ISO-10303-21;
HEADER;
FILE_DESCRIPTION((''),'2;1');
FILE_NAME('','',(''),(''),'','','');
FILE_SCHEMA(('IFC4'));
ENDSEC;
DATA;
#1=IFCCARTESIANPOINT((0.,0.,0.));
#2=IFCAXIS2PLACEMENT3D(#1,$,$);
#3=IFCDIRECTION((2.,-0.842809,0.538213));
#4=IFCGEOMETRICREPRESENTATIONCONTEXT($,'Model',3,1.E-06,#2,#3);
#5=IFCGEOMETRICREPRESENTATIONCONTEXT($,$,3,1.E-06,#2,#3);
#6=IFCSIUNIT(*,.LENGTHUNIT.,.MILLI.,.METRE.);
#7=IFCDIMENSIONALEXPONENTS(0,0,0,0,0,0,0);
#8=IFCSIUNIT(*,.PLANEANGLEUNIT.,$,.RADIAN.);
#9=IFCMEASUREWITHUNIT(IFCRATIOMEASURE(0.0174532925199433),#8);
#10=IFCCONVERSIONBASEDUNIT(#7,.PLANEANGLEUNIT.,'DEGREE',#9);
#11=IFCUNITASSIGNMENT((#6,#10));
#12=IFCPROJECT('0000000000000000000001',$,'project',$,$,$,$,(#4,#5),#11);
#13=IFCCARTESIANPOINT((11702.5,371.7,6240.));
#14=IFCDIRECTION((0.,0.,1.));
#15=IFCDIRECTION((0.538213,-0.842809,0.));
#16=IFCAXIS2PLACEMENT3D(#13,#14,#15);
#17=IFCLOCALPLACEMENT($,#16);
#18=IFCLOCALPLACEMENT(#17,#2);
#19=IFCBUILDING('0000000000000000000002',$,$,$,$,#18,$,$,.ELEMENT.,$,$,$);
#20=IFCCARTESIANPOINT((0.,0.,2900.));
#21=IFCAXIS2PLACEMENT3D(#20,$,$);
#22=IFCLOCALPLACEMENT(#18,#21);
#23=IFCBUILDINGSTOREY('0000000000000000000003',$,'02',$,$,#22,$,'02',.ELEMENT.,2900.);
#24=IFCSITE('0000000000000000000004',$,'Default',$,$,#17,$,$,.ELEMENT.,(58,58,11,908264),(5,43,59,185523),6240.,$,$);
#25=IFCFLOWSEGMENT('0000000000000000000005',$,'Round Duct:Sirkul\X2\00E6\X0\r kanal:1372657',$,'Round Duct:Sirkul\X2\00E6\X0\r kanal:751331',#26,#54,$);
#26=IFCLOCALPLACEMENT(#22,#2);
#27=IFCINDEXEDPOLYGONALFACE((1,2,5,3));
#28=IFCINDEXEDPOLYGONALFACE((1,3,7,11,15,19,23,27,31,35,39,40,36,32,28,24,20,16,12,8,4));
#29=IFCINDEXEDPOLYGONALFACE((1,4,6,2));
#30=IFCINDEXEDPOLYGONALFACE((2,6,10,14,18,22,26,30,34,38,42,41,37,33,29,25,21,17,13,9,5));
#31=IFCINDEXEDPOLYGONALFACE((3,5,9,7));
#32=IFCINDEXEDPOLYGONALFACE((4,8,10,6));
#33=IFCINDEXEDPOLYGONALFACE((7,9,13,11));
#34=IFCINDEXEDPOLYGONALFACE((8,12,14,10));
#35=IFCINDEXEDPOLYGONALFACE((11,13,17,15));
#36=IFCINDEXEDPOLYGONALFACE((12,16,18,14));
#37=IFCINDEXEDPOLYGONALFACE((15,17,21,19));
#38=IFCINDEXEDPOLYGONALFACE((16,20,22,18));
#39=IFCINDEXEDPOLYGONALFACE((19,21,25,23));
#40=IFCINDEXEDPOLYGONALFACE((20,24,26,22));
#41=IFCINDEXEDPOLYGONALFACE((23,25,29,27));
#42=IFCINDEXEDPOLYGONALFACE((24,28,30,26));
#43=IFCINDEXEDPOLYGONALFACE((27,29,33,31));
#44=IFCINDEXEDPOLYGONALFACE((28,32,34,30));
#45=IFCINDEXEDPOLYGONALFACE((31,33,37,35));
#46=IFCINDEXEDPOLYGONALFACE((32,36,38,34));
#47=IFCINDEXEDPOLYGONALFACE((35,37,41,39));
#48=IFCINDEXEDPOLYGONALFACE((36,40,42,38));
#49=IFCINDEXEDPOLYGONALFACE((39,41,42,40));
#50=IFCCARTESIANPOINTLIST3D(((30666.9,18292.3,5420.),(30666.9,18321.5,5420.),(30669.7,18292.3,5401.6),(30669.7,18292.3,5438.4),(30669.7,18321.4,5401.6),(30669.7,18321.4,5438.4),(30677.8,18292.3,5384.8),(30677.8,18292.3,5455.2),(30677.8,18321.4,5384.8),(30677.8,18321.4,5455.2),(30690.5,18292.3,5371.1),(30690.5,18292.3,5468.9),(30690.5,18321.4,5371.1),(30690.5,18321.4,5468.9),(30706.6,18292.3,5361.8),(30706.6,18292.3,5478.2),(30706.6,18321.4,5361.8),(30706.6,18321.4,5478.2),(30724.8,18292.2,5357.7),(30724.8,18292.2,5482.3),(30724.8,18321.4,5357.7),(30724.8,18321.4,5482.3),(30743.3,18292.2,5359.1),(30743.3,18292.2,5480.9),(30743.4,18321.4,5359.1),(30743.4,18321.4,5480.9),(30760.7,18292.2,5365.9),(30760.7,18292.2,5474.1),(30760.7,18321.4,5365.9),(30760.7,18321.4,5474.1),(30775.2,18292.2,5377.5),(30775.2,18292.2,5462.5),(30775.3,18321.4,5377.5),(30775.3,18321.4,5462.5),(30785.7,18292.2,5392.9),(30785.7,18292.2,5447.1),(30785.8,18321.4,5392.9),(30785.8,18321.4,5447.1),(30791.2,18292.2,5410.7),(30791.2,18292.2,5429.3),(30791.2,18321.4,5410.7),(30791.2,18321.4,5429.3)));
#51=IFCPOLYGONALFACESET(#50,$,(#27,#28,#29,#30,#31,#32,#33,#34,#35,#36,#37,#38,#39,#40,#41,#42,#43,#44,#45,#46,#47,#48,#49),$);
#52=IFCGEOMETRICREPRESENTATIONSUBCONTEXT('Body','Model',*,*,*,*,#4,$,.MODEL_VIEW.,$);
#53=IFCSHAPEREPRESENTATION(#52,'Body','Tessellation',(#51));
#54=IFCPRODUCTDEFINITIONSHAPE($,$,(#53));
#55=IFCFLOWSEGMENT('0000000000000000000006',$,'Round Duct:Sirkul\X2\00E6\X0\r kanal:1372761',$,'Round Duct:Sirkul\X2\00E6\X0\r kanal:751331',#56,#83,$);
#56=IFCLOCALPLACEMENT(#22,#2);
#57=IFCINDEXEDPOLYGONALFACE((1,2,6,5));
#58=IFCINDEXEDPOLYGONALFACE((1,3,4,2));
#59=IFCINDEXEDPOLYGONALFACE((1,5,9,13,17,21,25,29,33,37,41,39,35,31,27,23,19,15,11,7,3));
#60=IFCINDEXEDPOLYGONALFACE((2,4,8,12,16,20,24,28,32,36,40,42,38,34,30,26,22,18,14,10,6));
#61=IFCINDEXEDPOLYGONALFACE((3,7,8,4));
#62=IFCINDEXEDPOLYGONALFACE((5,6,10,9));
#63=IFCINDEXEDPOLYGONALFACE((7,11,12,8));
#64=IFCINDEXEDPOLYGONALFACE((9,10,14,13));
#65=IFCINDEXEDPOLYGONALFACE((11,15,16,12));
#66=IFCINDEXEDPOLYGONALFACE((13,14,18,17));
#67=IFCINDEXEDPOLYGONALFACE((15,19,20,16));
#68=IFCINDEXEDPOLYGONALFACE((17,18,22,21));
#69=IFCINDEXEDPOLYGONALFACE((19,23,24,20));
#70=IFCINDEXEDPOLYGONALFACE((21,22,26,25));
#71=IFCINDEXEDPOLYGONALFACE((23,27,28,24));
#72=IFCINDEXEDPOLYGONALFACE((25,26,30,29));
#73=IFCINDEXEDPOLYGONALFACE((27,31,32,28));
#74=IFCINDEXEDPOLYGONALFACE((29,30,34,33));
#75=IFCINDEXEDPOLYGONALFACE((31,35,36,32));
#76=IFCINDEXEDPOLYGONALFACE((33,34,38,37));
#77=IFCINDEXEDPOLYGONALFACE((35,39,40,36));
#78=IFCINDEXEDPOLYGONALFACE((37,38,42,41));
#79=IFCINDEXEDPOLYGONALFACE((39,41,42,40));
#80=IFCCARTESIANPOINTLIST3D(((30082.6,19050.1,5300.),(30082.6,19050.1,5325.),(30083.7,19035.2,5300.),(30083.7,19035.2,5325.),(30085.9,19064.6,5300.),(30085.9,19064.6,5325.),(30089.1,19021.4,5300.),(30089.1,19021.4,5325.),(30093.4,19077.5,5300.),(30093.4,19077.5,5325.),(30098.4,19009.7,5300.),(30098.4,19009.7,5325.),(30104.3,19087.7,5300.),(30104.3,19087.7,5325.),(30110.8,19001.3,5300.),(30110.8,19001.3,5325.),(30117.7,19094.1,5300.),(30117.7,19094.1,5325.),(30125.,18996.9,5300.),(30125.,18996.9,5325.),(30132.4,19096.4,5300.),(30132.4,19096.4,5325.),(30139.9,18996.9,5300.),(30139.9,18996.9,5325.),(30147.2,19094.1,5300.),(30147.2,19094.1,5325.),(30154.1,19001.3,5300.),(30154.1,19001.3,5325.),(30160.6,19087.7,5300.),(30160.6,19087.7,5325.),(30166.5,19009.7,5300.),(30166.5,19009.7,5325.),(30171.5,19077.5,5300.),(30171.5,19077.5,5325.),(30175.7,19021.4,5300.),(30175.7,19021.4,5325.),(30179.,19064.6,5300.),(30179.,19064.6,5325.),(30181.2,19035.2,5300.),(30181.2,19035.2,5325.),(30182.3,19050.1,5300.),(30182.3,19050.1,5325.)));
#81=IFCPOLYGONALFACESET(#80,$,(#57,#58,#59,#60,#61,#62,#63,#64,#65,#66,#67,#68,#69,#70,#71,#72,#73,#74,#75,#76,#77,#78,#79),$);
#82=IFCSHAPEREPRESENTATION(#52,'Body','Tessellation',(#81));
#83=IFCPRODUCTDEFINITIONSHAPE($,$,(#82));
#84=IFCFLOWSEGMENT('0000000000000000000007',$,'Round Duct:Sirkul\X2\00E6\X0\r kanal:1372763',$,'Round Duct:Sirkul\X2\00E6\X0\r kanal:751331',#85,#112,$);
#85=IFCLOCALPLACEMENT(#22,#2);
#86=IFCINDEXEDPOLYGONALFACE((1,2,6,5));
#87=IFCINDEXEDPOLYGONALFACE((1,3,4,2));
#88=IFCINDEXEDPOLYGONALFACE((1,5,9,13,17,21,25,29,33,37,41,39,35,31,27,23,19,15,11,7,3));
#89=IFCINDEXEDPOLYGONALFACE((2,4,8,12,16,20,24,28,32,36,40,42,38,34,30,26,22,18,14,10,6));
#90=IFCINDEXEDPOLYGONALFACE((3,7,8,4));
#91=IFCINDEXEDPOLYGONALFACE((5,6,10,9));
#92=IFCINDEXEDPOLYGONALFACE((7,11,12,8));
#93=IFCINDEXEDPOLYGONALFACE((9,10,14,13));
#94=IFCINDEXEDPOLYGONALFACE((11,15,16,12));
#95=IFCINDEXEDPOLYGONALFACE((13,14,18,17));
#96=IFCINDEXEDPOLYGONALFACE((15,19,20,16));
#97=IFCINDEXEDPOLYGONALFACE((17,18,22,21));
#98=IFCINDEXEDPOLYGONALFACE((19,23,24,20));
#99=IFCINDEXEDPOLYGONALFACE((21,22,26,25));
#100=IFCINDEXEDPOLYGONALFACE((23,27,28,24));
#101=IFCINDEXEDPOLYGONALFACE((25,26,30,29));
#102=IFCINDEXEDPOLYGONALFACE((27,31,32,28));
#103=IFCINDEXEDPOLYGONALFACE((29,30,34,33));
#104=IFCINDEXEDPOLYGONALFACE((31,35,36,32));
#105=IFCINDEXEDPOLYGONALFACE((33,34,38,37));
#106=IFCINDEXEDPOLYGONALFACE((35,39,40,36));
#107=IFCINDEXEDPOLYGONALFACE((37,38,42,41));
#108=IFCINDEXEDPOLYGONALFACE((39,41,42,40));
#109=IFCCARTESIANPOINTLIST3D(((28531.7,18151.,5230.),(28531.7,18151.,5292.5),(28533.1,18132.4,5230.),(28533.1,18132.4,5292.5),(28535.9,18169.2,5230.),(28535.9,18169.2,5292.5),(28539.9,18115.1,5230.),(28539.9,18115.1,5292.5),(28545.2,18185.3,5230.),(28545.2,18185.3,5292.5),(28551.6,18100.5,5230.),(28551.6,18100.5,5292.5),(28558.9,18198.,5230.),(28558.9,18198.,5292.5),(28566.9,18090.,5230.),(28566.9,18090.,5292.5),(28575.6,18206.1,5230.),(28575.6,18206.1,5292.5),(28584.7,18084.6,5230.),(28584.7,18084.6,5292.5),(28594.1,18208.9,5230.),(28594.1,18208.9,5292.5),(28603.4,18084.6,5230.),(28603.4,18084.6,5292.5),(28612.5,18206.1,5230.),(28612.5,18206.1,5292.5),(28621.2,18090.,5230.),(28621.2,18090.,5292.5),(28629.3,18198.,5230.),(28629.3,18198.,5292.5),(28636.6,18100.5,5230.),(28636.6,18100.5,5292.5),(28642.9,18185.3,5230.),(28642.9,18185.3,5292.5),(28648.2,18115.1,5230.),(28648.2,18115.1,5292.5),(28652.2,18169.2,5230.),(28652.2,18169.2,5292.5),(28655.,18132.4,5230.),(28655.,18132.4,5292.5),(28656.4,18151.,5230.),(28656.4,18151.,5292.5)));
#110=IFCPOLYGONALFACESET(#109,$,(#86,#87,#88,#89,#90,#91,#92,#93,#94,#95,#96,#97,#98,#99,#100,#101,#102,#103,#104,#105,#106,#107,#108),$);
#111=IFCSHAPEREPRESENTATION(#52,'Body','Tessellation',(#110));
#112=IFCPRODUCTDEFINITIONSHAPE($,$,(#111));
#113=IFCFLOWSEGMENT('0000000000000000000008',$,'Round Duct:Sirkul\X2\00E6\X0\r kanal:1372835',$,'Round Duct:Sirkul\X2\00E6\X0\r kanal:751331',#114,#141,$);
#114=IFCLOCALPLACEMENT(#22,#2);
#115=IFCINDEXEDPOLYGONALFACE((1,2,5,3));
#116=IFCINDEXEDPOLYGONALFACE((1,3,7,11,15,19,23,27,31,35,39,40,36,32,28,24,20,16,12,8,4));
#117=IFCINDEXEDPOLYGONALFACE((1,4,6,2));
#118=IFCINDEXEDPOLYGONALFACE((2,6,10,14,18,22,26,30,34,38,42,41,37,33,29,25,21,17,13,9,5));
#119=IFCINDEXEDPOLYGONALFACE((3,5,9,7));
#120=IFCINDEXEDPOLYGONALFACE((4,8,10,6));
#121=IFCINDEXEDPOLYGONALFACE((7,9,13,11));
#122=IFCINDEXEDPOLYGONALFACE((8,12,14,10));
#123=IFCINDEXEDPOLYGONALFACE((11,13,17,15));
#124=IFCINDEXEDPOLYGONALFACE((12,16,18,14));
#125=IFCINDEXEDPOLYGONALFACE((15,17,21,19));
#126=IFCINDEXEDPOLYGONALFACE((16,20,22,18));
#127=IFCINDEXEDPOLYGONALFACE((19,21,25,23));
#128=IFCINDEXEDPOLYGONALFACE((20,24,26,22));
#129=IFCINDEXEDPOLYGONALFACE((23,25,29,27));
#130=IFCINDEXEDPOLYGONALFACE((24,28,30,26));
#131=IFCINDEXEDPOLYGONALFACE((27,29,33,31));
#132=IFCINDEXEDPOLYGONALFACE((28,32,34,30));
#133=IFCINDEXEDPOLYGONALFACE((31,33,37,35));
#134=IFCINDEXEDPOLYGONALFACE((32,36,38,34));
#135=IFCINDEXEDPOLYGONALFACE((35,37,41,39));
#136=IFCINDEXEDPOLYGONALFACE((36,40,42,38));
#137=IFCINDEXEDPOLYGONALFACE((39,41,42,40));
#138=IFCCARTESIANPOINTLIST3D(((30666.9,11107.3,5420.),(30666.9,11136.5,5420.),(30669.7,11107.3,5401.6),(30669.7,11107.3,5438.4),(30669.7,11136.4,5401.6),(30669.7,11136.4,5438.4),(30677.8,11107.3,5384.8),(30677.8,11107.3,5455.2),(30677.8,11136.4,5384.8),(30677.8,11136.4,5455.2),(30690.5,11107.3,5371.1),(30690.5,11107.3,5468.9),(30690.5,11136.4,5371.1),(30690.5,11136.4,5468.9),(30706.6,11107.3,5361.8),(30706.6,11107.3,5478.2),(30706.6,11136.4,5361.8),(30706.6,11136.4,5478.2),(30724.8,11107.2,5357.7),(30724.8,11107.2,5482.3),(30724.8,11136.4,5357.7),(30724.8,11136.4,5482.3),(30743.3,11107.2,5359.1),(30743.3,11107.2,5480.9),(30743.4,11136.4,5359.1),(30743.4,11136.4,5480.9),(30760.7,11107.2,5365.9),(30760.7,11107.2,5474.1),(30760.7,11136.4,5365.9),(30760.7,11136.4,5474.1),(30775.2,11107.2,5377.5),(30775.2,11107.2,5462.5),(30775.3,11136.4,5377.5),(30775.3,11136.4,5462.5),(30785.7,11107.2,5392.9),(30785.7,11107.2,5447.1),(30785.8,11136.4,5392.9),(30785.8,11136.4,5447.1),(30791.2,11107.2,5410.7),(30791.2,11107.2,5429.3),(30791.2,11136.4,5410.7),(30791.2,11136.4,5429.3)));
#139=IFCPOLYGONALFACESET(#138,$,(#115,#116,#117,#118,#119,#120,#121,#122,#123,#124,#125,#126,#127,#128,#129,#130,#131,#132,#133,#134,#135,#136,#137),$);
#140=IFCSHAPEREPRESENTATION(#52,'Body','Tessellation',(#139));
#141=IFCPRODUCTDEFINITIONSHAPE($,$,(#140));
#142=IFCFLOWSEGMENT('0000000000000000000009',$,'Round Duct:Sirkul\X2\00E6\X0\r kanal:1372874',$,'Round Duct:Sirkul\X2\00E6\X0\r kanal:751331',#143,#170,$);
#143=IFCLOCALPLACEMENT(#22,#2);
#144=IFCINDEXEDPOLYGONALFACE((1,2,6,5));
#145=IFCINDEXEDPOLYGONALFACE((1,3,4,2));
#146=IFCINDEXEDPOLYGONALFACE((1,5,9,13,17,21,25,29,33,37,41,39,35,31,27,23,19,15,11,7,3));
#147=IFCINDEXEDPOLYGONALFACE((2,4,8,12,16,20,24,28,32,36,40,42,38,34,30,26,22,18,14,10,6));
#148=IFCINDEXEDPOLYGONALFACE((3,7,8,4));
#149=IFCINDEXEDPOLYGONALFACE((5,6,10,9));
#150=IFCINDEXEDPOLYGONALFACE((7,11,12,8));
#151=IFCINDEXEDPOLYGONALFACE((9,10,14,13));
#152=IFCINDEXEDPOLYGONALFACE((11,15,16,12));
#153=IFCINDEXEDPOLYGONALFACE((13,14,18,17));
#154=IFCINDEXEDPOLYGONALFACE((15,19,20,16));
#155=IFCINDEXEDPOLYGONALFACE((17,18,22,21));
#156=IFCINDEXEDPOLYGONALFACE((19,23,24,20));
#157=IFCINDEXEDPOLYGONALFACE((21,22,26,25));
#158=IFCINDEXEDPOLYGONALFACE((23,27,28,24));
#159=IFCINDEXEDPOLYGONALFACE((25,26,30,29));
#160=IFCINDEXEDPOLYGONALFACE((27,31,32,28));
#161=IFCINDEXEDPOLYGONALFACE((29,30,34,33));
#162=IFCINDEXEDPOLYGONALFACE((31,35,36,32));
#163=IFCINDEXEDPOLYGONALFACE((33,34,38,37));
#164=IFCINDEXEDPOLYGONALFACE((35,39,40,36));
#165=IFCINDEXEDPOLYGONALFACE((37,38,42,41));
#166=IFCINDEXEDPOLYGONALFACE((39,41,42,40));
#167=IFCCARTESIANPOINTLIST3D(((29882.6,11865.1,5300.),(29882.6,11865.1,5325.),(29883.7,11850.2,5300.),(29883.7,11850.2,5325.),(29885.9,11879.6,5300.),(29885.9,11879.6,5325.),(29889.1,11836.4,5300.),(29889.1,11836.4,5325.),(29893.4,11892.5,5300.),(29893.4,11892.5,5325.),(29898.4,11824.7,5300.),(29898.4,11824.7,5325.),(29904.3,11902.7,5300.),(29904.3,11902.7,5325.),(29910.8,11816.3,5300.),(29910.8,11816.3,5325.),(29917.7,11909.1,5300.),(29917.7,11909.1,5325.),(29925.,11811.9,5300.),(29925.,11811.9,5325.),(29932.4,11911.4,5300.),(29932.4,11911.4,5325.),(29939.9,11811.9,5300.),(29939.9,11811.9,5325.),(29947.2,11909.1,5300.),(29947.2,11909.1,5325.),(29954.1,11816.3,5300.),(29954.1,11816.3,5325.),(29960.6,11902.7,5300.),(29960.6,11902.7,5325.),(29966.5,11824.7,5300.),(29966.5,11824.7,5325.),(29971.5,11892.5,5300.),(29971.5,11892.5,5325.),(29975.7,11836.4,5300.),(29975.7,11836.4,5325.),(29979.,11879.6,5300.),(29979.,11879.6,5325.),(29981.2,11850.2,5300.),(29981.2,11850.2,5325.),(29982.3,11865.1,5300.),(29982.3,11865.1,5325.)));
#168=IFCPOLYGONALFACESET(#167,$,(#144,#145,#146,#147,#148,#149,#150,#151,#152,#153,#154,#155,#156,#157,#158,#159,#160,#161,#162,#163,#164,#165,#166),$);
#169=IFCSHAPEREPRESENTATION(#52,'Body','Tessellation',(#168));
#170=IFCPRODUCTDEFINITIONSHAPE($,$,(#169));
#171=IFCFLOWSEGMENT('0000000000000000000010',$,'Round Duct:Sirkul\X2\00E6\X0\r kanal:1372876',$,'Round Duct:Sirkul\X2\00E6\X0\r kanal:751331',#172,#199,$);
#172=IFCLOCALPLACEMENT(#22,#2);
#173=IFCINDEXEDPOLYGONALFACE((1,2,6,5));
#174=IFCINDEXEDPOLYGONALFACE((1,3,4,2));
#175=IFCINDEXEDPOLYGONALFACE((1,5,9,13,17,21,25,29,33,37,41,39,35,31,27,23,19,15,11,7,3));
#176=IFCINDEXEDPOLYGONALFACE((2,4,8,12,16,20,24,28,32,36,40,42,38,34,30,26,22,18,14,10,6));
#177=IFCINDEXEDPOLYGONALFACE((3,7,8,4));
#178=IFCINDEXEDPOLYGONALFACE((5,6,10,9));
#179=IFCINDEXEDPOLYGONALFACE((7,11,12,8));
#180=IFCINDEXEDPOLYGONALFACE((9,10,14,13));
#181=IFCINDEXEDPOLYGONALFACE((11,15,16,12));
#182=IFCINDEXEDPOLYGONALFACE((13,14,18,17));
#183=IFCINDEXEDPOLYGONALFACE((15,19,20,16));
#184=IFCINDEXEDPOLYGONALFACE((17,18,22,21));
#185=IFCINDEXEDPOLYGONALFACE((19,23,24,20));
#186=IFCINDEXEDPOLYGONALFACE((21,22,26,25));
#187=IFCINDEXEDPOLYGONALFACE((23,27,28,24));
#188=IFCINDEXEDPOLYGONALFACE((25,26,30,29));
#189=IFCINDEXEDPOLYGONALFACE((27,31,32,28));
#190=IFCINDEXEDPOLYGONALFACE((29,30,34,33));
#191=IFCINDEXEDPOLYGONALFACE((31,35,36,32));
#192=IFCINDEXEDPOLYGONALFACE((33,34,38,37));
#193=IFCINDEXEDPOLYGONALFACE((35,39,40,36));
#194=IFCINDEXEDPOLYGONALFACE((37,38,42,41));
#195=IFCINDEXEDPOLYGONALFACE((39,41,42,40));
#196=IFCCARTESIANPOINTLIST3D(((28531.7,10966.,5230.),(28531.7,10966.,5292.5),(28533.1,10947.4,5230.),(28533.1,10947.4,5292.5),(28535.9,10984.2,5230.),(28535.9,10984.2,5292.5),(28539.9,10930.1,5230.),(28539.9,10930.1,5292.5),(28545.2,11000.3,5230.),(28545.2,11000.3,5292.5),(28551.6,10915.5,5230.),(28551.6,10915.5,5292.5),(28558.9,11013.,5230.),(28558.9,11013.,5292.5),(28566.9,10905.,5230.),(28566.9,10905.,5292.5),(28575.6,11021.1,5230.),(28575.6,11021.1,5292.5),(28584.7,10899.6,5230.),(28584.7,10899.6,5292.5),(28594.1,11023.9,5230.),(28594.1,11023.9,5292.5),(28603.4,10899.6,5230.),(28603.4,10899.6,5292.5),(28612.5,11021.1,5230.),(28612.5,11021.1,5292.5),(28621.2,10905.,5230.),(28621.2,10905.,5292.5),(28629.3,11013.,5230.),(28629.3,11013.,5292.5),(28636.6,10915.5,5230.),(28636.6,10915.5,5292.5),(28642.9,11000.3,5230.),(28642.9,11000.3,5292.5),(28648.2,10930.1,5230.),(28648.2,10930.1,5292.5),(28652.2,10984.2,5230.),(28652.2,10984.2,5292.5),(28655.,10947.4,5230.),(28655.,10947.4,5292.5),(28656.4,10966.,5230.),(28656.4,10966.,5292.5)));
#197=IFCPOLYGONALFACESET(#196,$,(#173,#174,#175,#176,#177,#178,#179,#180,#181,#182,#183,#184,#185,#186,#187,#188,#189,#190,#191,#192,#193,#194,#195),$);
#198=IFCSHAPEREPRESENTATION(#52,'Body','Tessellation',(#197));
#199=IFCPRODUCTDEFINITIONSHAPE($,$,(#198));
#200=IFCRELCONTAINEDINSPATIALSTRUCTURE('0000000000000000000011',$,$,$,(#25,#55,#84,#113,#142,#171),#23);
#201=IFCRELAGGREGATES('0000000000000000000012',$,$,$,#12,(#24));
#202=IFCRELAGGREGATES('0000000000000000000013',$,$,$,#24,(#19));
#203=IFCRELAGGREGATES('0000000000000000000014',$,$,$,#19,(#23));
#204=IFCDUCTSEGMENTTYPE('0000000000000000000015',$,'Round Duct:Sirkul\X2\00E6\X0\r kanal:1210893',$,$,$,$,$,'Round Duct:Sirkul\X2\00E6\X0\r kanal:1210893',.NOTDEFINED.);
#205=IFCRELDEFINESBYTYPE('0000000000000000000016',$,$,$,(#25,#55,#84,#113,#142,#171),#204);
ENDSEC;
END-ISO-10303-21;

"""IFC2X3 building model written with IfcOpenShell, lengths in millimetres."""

from ifc_helpers import new_model, entity, si_unit, converted_unit, direction, frame, frame_2d, origin, origin_2d_with_axis, place, context, subcontext, project, spatial, circle, extrude, type_object, element, save


model = new_model("IFC2X3")

# Units and contexts
model_context = context("Model", 3, precision=1e-06, world=origin(), true_north=direction((2.0, -0.842809, 0.538213)))
context_of_model = context(None, 3, precision=1e-06, world=origin(), true_north=direction((2.0, -0.842809, 0.538213)))
body_context = subcontext(model_context, "Body", "Model", "MODEL_VIEW")
ifc_project = project(units=[si_unit("LENGTHUNIT", "METRE", prefix="MILLI"), converted_unit("PLANEANGLEUNIT", "DEGREE", entity("IfcRatioMeasure", 0.0174532925199433), si_unit("PLANEANGLEUNIT", "RADIAN"), dimensions=[0, 0, 0, 0, 0, 0, 0])], contexts=[model_context, context_of_model])

# Site, building, storey
site_placement = place(None, frame((11702.5, 371.7, 6240.0), z_axis=(0.0, 0.0, 1.0), x_axis=(0.538213, -0.842809, 0.0)))
site = spatial("IfcSite", under=ifc_project, at=site_placement, Name="Default", CompositionType="ELEMENT", RefLatitude=(58, 58, 11, 908264), RefLongitude=(5, 43, 59, 185523), RefElevation=6240.0)
building_placement = place(site_placement, origin())
building = spatial("IfcBuilding", under=site, at=building_placement, CompositionType="ELEMENT")
storey_placement = place(building_placement, frame((0.0, 0.0, 2900.0)))
storey = spatial("IfcBuildingStorey", under=building, at=storey_placement, Name="02", LongName="02", CompositionType="ELEMENT", Elevation=2900.0)

# Flow segments
duct_segment_type = type_object("IfcDuctSegmentType", Name="Round Duct:Sirkulær kanal:1210893", ElementType="Round Duct:Sirkulær kanal:1210893", PredefinedType="NOTDEFINED")
flow_segment_1_placement = place(storey_placement, origin())
element("IfcFlowSegment", 1, at=flow_segment_1_placement, inside=storey, type_object=duct_segment_type, Name="Round Duct:Sirkulær kanal:1372657", ObjectType="Round Duct:Sirkulær kanal:751331", context=body_context, shape_type="SweptSolid", body=[
    extrude(circle(Radius=62.5, at=origin_2d_with_axis()), frame((30729.4, 18292.2, 5420.0), z_axis=(0.000629, 1.0, 0.0), x_axis=(-1.0, 0.000629, 0.0)), (0.0, 0.0, 1.0), 29.2),
])
flow_segment_2_placement = place(storey_placement, origin())
element("IfcFlowSegment", 2, at=flow_segment_2_placement, inside=storey, type_object=duct_segment_type, Name="Round Duct:Sirkulær kanal:1372761", ObjectType="Round Duct:Sirkulær kanal:751331", context=body_context, shape_type="SweptSolid", body=[
    extrude(circle(Radius=50.0, at=frame_2d((0.0, 0.0), x_axis=(1.0, 0.0))), frame((30132.4, 19046.4, 5300.0), z_axis=(0.0, 0.0, 1.0), x_axis=(0.0, 1.0, 0.0)), (0.0, 0.0, 1.0), 25.0),
])
flow_segment_3_placement = place(storey_placement, origin())
element("IfcFlowSegment", 3, at=flow_segment_3_placement, inside=storey, type_object=duct_segment_type, Name="Round Duct:Sirkulær kanal:1372763", ObjectType="Round Duct:Sirkulær kanal:751331", context=body_context, shape_type="SweptSolid", body=[
    extrude(circle(Radius=62.5, at=frame_2d((0.0, 0.0), x_axis=(1.0, 0.0))), frame((28594.1, 18146.4, 5230.0), z_axis=(0.0, 0.0, 1.0), x_axis=(0.0, 1.0, 0.0)), (0.0, 0.0, 1.0), 62.5),
])
flow_segment_4_placement = place(storey_placement, origin())
element("IfcFlowSegment", 4, at=flow_segment_4_placement, inside=storey, type_object=duct_segment_type, Name="Round Duct:Sirkulær kanal:1372835", ObjectType="Round Duct:Sirkulær kanal:751331", context=body_context, shape_type="SweptSolid", body=[
    extrude(circle(Radius=62.5, at=origin_2d_with_axis()), frame((30729.4, 11107.2, 5420.0), z_axis=(0.000629, 1.0, 0.0), x_axis=(-1.0, 0.000629, 0.0)), (0.0, 0.0, 1.0), 29.2),
])
flow_segment_5_placement = place(storey_placement, origin())
element("IfcFlowSegment", 5, at=flow_segment_5_placement, inside=storey, type_object=duct_segment_type, Name="Round Duct:Sirkulær kanal:1372874", ObjectType="Round Duct:Sirkulær kanal:751331", context=body_context, shape_type="SweptSolid", body=[
    extrude(circle(Radius=50.0, at=frame_2d((0.0, 0.0), x_axis=(1.0, 0.0))), frame((29932.4, 11861.4, 5300.0), z_axis=(0.0, 0.0, 1.0), x_axis=(0.0, 1.0, 0.0)), (0.0, 0.0, 1.0), 25.0),
])
flow_segment_6_placement = place(storey_placement, origin())
element("IfcFlowSegment", 6, at=flow_segment_6_placement, inside=storey, type_object=duct_segment_type, Name="Round Duct:Sirkulær kanal:1372876", ObjectType="Round Duct:Sirkulær kanal:751331", context=body_context, shape_type="SweptSolid", body=[
    extrude(circle(Radius=62.5, at=frame_2d((0.0, 0.0), x_axis=(1.0, 0.0))), frame((28594.1, 10961.4, 5230.0), z_axis=(0.0, 0.0, 1.0), x_axis=(0.0, 1.0, 0.0)), (0.0, 0.0, 1.0), 62.5),
])

save(model, "model.ifc")
